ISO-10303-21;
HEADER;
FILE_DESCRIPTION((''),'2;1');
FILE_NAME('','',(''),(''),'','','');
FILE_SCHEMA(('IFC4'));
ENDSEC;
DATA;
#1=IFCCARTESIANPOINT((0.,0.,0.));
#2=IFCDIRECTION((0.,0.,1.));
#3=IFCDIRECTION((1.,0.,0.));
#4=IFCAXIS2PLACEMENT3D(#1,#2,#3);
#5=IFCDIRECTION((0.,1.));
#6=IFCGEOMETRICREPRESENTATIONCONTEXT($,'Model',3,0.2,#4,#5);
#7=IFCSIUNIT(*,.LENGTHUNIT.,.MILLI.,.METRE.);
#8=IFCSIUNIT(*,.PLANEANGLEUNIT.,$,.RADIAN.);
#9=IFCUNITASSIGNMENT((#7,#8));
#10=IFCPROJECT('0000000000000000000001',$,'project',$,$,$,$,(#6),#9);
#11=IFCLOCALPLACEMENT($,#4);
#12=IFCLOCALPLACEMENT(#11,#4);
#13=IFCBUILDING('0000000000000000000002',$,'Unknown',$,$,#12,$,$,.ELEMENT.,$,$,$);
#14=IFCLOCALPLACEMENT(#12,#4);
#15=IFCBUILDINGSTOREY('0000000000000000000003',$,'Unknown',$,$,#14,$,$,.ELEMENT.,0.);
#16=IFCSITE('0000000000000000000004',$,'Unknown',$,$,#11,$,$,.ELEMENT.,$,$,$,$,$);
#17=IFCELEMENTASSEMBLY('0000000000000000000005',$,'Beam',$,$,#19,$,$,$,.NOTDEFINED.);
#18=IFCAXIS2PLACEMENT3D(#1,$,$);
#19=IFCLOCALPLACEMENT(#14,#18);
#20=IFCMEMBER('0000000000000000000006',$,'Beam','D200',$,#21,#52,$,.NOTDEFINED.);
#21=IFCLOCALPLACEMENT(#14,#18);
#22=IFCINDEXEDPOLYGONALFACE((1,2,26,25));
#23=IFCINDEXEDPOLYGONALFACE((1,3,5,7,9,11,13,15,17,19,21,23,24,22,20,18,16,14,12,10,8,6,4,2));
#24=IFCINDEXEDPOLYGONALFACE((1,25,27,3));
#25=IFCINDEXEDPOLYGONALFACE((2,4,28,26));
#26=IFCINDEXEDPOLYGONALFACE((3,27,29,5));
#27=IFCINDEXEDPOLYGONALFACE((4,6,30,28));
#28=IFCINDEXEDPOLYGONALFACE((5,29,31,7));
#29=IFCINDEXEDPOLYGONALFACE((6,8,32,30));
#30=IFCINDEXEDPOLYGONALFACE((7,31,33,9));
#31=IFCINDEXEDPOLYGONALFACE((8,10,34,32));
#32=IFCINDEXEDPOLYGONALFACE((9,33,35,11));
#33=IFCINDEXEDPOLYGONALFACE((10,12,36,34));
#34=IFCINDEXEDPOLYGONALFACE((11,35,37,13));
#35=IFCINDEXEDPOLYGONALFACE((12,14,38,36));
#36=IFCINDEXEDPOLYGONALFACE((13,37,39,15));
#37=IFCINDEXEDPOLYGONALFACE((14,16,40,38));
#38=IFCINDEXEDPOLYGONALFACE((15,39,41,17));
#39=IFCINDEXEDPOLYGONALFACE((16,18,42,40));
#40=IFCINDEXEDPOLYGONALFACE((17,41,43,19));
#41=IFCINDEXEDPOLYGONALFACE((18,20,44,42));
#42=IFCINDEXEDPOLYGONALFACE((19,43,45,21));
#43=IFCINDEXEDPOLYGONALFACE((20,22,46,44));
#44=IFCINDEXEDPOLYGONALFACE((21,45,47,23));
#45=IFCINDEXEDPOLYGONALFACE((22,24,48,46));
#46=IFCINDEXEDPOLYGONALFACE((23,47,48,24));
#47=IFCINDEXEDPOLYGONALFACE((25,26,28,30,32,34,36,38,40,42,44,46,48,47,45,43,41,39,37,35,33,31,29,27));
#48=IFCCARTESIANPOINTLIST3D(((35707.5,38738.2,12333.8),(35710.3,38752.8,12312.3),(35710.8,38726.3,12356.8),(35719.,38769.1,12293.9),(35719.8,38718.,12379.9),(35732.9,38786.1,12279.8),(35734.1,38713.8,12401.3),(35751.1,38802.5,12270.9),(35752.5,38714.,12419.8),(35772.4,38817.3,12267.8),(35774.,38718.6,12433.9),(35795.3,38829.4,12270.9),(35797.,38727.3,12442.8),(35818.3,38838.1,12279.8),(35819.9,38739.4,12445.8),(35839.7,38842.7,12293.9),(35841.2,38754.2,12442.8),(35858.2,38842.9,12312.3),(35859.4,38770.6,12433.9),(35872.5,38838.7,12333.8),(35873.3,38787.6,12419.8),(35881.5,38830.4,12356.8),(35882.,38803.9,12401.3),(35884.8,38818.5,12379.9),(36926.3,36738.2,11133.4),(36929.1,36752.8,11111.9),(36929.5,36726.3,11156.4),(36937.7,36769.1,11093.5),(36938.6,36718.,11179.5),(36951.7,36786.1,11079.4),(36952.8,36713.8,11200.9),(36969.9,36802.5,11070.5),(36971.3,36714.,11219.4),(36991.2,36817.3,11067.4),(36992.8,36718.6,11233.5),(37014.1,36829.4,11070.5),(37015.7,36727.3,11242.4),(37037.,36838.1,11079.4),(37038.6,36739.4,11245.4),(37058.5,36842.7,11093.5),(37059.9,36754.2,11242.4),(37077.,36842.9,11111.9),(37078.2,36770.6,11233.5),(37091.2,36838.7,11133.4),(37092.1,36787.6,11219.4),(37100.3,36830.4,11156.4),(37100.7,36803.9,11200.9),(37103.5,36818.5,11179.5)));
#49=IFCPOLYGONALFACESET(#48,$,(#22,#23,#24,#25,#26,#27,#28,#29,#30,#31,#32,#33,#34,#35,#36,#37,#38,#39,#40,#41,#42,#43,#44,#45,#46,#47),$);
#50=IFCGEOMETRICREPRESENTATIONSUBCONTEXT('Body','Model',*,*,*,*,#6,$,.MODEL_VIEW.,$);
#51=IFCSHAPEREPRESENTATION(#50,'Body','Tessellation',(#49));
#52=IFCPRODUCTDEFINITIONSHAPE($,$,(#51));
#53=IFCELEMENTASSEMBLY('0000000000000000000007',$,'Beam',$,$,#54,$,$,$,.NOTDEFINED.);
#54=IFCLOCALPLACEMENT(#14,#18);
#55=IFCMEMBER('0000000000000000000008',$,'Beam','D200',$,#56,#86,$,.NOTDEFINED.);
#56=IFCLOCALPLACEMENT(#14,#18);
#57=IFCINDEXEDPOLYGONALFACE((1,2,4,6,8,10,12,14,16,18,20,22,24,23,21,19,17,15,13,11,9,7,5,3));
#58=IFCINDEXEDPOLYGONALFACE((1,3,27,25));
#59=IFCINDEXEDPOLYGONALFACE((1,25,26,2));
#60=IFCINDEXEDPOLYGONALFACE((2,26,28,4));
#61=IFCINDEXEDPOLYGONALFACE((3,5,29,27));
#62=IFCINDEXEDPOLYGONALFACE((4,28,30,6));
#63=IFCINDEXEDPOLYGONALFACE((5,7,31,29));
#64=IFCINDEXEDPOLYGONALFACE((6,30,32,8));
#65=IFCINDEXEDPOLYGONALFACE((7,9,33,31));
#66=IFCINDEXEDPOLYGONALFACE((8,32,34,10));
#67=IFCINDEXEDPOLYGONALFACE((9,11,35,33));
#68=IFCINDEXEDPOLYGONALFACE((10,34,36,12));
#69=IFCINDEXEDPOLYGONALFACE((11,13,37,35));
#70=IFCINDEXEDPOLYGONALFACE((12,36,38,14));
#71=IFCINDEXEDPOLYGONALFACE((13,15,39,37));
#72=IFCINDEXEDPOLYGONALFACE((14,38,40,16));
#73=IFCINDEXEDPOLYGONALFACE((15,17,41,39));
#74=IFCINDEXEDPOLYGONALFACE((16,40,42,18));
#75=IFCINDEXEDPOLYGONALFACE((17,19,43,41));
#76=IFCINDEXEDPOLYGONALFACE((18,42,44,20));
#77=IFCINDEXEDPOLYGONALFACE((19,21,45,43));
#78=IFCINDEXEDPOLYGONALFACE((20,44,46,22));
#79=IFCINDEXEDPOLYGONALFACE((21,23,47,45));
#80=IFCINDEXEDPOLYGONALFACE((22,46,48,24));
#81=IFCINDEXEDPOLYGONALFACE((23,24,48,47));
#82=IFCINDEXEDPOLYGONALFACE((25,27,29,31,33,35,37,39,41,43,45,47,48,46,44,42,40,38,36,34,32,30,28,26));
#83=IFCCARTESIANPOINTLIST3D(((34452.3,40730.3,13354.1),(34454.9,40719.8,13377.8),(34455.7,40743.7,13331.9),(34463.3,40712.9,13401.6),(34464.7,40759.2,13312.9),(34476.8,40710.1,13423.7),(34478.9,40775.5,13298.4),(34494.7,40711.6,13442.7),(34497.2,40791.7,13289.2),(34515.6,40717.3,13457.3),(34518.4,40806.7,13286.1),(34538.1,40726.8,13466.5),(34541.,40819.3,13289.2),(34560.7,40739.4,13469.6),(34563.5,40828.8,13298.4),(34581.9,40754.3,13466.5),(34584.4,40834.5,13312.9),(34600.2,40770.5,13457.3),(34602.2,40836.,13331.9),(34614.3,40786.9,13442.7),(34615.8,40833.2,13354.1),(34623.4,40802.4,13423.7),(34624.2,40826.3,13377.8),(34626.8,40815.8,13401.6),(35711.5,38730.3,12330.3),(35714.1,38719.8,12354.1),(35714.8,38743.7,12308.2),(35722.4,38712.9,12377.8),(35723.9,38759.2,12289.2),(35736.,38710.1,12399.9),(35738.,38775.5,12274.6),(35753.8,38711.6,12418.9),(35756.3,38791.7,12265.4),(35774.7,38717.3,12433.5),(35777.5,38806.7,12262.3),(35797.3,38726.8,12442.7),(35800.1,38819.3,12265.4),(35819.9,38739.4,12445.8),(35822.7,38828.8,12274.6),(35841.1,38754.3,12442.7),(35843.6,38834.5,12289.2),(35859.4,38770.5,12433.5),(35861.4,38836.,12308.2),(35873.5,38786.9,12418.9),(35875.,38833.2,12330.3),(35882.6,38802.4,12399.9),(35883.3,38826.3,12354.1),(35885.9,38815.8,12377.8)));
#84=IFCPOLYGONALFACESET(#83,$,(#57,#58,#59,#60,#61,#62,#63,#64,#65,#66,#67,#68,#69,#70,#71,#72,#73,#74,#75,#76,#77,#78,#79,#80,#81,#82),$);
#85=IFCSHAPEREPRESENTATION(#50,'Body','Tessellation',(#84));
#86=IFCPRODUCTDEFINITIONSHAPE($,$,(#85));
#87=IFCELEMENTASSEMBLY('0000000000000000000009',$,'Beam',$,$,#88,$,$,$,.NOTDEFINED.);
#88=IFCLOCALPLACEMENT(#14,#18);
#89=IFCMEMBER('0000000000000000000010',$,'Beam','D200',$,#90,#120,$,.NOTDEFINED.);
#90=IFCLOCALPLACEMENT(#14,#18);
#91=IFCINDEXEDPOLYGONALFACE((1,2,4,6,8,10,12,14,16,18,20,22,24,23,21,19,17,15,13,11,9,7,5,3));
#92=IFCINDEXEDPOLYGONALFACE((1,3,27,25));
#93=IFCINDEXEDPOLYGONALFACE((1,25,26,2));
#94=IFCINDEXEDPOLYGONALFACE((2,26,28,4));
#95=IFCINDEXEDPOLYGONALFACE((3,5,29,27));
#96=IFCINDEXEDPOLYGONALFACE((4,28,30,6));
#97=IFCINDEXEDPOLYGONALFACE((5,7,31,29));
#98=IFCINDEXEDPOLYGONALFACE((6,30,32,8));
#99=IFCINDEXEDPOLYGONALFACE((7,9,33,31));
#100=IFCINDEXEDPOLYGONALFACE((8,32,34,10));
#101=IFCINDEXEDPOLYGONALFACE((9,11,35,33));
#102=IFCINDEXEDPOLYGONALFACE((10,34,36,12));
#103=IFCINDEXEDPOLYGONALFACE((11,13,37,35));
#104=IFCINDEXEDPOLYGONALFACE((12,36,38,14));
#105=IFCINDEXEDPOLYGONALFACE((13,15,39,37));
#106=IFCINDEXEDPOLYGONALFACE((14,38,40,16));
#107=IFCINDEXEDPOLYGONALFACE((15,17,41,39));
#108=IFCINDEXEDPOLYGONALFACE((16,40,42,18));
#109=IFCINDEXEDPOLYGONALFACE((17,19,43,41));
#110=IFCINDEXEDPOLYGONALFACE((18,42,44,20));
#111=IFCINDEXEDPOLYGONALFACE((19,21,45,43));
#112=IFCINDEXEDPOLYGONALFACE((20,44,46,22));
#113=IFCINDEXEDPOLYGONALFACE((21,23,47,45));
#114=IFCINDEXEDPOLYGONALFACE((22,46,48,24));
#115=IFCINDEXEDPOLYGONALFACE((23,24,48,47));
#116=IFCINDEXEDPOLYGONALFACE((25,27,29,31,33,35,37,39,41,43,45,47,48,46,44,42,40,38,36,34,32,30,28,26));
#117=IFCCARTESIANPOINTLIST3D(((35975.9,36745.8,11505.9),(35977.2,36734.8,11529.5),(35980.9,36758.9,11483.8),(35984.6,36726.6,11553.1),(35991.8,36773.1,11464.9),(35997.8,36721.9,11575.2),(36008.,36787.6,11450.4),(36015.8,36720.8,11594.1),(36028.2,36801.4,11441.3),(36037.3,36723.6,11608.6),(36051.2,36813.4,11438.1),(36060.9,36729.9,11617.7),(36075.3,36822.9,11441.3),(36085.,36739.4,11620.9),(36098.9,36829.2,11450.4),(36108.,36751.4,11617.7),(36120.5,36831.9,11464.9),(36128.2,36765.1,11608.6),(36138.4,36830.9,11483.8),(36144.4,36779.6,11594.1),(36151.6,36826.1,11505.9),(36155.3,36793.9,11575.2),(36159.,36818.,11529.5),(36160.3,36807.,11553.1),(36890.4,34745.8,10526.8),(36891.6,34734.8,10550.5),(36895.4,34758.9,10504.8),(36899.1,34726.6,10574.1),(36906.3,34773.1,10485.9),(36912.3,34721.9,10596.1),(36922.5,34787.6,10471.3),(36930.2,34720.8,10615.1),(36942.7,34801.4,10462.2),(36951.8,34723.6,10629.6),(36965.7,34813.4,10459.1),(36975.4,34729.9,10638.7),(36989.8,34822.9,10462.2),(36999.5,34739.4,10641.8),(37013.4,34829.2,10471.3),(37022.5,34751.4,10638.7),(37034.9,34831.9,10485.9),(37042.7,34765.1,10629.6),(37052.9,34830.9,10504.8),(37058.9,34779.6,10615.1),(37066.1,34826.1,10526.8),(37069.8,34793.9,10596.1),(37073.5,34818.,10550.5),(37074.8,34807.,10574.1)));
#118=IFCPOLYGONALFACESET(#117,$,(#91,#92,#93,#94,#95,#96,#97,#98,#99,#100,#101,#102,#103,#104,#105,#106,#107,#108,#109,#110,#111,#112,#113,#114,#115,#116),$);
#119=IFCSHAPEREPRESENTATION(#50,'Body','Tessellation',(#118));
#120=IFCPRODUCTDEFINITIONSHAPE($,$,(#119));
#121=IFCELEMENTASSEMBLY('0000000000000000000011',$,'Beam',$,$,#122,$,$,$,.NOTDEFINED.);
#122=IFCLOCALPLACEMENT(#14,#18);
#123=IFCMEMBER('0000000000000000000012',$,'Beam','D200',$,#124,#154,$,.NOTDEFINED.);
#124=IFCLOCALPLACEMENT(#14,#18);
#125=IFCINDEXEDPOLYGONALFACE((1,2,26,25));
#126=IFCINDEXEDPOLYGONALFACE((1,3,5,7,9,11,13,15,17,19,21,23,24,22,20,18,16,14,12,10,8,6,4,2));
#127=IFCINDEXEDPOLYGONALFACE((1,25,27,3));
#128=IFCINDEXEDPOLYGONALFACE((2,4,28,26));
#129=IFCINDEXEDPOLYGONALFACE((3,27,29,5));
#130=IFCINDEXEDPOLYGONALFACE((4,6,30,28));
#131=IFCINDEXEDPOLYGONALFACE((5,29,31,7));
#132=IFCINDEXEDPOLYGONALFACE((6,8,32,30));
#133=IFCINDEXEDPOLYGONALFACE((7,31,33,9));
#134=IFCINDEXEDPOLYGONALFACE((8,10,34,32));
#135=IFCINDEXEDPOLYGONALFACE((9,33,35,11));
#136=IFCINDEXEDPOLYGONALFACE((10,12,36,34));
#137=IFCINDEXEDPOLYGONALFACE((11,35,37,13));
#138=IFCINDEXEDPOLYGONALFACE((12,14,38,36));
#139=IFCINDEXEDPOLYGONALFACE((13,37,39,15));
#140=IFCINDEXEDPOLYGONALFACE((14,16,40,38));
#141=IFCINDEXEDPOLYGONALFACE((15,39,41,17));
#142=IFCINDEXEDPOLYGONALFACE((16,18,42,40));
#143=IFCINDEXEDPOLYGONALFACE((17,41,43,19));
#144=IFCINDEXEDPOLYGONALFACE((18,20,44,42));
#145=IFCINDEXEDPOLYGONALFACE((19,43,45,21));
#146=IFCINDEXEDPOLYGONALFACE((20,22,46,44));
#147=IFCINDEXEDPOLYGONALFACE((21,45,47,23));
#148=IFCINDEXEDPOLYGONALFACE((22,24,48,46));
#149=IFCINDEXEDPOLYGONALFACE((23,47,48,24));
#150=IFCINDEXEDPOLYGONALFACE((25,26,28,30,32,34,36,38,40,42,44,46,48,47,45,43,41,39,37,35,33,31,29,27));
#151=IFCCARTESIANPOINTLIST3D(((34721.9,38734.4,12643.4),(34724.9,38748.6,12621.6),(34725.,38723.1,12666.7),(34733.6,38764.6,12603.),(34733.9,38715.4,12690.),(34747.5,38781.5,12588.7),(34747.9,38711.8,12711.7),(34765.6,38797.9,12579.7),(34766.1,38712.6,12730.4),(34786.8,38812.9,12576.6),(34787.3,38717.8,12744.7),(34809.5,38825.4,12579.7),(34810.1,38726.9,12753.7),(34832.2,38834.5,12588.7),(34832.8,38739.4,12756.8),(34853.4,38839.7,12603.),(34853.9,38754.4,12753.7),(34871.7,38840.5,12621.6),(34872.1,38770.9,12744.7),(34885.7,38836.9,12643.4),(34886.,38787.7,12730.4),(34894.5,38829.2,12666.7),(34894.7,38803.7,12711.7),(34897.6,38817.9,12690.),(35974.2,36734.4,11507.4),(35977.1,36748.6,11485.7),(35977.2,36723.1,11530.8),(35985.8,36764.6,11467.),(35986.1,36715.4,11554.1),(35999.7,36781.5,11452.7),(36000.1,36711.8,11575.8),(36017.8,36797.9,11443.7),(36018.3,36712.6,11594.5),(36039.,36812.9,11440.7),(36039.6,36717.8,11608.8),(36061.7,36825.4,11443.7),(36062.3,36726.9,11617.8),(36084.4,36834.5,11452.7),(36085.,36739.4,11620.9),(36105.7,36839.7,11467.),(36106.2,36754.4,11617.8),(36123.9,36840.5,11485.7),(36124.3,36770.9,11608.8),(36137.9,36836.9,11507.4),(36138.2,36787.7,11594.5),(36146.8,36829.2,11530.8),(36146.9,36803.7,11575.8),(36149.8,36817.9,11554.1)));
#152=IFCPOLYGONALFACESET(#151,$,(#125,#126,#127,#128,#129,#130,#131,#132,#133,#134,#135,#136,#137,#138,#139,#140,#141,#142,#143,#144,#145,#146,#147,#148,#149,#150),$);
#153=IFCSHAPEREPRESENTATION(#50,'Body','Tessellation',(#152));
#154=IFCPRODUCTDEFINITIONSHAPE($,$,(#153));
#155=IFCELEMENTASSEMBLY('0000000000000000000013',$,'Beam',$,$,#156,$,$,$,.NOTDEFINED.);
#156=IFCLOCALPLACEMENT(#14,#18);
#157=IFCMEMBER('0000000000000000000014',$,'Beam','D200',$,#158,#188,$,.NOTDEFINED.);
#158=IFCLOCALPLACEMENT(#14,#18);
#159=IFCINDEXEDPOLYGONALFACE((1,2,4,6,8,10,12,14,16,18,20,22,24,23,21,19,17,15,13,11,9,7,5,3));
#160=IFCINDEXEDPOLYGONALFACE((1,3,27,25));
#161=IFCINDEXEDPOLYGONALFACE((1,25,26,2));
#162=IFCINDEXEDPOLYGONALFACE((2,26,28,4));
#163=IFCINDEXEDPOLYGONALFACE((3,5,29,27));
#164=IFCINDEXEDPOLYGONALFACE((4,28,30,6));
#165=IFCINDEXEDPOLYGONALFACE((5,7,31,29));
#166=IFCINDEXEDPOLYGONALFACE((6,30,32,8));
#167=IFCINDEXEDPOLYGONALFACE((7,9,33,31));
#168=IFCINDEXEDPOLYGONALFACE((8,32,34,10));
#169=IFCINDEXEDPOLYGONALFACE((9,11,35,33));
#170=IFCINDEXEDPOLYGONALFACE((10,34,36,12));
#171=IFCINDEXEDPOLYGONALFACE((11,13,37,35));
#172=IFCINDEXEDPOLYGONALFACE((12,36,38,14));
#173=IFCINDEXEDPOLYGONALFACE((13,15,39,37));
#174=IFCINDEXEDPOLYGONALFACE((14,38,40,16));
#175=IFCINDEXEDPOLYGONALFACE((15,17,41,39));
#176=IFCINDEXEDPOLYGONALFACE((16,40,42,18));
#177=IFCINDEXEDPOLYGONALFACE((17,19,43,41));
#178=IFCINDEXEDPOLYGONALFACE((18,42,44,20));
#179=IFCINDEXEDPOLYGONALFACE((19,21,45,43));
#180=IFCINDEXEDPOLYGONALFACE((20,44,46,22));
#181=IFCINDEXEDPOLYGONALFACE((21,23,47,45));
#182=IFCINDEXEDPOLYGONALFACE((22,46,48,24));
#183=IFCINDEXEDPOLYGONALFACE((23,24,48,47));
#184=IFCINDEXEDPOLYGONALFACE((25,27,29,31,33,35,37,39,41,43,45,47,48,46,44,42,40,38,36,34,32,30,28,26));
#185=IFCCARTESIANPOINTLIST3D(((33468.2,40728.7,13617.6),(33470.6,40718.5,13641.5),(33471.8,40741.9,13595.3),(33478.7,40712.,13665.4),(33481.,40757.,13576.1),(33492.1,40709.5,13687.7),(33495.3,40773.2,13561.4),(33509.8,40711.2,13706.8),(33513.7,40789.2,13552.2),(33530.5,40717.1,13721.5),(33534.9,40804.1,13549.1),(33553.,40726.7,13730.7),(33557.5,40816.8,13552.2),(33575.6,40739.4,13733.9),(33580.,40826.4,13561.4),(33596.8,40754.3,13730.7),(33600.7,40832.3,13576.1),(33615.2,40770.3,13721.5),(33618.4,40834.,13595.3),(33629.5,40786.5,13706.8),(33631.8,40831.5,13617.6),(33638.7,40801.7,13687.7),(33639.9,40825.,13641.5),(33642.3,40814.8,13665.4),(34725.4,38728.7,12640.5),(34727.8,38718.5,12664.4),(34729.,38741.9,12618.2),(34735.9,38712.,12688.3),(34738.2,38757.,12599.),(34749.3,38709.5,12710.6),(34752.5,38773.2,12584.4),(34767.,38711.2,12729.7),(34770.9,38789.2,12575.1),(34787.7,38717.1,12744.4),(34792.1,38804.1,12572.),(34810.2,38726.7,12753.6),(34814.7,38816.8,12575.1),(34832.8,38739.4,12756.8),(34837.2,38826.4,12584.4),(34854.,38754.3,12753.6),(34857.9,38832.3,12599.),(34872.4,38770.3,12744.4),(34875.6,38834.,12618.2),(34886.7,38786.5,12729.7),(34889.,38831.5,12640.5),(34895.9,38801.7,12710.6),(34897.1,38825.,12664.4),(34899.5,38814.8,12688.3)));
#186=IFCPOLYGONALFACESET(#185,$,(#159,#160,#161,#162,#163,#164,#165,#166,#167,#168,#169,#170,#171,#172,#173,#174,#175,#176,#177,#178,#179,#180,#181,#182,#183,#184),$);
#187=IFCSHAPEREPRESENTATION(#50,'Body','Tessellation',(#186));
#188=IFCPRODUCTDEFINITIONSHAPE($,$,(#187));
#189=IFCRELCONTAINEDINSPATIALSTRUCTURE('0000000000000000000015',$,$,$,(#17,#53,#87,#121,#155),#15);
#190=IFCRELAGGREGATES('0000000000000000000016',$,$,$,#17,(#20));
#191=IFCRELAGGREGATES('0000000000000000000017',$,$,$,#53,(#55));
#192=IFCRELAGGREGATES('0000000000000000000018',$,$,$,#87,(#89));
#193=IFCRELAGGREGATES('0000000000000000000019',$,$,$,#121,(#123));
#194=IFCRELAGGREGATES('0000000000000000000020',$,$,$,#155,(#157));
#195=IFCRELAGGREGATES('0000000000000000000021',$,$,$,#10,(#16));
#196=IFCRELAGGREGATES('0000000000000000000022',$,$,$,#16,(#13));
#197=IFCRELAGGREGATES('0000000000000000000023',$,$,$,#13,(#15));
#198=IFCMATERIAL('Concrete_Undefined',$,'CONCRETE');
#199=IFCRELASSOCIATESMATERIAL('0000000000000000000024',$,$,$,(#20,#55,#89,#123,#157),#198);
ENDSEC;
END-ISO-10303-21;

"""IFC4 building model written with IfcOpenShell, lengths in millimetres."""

from ifc_helpers import new_model, si_unit, direction, frame, origin_with_axes, place, context, subcontext, project, spatial, line, indexed_curve, outline, extrude, material, element, aggregate, save


model = new_model("IFC4")

# Units and contexts
model_context = context("Model", 3, precision=0.2, world=origin_with_axes(), true_north=direction((0.0, 1.0)))
body_context = subcontext(model_context, "Body", "Model", "MODEL_VIEW")
ifc_project = project(units=[si_unit("LENGTHUNIT", "METRE", prefix="MILLI"), si_unit("PLANEANGLEUNIT", "RADIAN")], contexts=[model_context])

# Site, building, storey
site_placement = place(None, origin_with_axes())
site = spatial("IfcSite", under=ifc_project, at=site_placement, Name="Unknown", CompositionType="ELEMENT")
building_placement = place(site_placement, origin_with_axes())
building = spatial("IfcBuilding", under=site, at=building_placement, Name="Unknown", CompositionType="ELEMENT")
storey_placement = place(building_placement, origin_with_axes())
storey = spatial("IfcBuildingStorey", under=building, at=storey_placement, Name="Unknown", CompositionType="ELEMENT", Elevation=0.0)

# Shared definitions
ifc_material = material(Name="Concrete_Undefined", Category="CONCRETE")

# Element assemblies, members
assembly_1_placement = place(storey_placement, frame((35796.1, 38778.4, 12356.8), z_axis=(-0.853939, -0.520374, 0.0), x_axis=(0.463091, -0.759937, -0.456116)))
assembly_1 = element("IfcElementAssembly", 1, at=assembly_1_placement, inside=storey, Name="Beam", PredefinedType="NOTDEFINED")
member_1_placement = place(assembly_1_placement, origin_with_axes())
member_1 = element("IfcMember", 2, at=member_1_placement, material=ifc_material, Name="Beam", Description="D200", PredefinedType="NOTDEFINED", context=body_context, shape_type="SolidModel", body=[
    extrude(outline(indexed_curve([(100.0, 0.0), (96.6, 25.9), (86.6, 50.0), (70.7, 70.7), (50.0, 86.6), (25.9, 96.6), (0.0, 100.0), (-25.9, 96.6), (-50.0, 86.6), (-70.7, 70.7), (-86.6, 50.0), (-96.6, 25.9), (-100.0, 0.0), (-96.6, -25.9), (-86.6, -50.0), (-70.7, -70.7), (-50.0, -86.6), (-25.9, -96.6), (0.0, -100.0), (25.9, -96.6), (50.0, -86.6), (70.7, -70.7), (86.6, -50.0), (96.6, -25.9)], segments=[line(1, 2, 3, 4, 5, 6, 7, 8, 9, 10, 11, 12, 13, 14, 15, 16, 17, 18, 19, 20, 21, 22, 23, 24, 1)])), frame((0.0, 0.0, 0.0), z_axis=(-1.0, 0.0, 0.0), x_axis=(0.0, 0.0, 1.0)), (0.0, 0.0, -1.0), 2631.8),
])
aggregate(assembly_1, [member_1])
assembly_2_placement = place(storey_placement, frame((34539.5, 40773.0, 13377.8), z_axis=(-0.846249, -0.532787, 0.0), x_axis=(0.488889, -0.776524, -0.397489)))
assembly_2 = element("IfcElementAssembly", 3, at=assembly_2_placement, inside=storey, Name="Beam", PredefinedType="NOTDEFINED")
member_2_placement = place(assembly_2_placement, origin_with_axes())
member_2 = element("IfcMember", 4, at=member_2_placement, material=ifc_material, Name="Beam", Description="D200", PredefinedType="NOTDEFINED", context=body_context, shape_type="SolidModel", body=[
    extrude(outline(indexed_curve([(100.0, 0.0), (96.6, 25.9), (86.6, 50.0), (70.7, 70.7), (50.0, 86.6), (25.9, 96.6), (0.0, 100.0), (-25.9, 96.6), (-50.0, 86.6), (-70.7, 70.7), (-86.6, 50.0), (-96.6, 25.9), (-100.0, 0.0), (-96.6, -25.9), (-86.6, -50.0), (-70.7, -70.7), (-50.0, -86.6), (-25.9, -96.6), (0.0, -100.0), (25.9, -96.6), (50.0, -86.6), (70.7, -70.7), (86.6, -50.0), (96.6, -25.9)], segments=[line(1, 2, 3, 4, 5, 6, 7, 8, 9, 10, 11, 12, 13, 14, 15, 16, 17, 18, 19, 20, 21, 22, 23, 24, 1)])), frame((0.0, 0.0, 0.0), z_axis=(-1.0, 0.0, 0.0), x_axis=(0.0, 0.0, 1.0)), (0.0, 0.0, -1.0), 2575.6),
])
aggregate(assembly_2, [member_2])

# Element assemblies, members
assembly_3_placement = place(storey_placement, frame((36068.1, 36776.4, 11529.5), z_axis=(-0.909439, -0.415837, 0.0), x_axis=(0.379892, -0.830827, -0.406705)))
assembly_3 = element("IfcElementAssembly", 5, at=assembly_3_placement, inside=storey, Name="Beam", PredefinedType="NOTDEFINED")
member_3_placement = place(assembly_3_placement, origin_with_axes())
member_3 = element("IfcMember", 6, at=member_3_placement, material=ifc_material, Name="Beam", Description="D200", PredefinedType="NOTDEFINED", context=body_context, shape_type="SolidModel", body=[
    extrude(outline(indexed_curve([(100.0, 0.0), (96.6, 25.9), (86.6, 50.0), (70.7, 70.7), (50.0, 86.6), (25.9, 96.6), (0.0, 100.0), (-25.9, 96.6), (-50.0, 86.6), (-70.7, 70.7), (-86.6, 50.0), (-96.6, 25.9), (-100.0, 0.0), (-96.6, -25.9), (-86.6, -50.0), (-70.7, -70.7), (-50.0, -86.6), (-25.9, -96.6), (0.0, -100.0), (25.9, -96.6), (50.0, -86.6), (70.7, -70.7), (86.6, -50.0), (96.6, -25.9)], segments=[line(1, 2, 3, 4, 5, 6, 7, 8, 9, 10, 11, 12, 13, 14, 15, 16, 17, 18, 19, 20, 21, 22, 23, 24, 1)])), frame((0.0, 0.0, 0.0), z_axis=(-1.0, 0.0, 0.0), x_axis=(0.0, 0.0, 1.0)), (0.0, 0.0, -1.0), 2407.2),
])
aggregate(assembly_3, [member_3])
assembly_4_placement = place(storey_placement, frame((34809.8, 38776.2, 12666.7), z_axis=(-0.847575, -0.530676, 0.0), x_axis=(0.478156, -0.763692, -0.433754)))
assembly_4 = element("IfcElementAssembly", 7, at=assembly_4_placement, inside=storey, Name="Beam", PredefinedType="NOTDEFINED")
member_4_placement = place(assembly_4_placement, origin_with_axes())
member_4 = element("IfcMember", 8, at=member_4_placement, material=ifc_material, Name="Beam", Description="D200", PredefinedType="NOTDEFINED", context=body_context, shape_type="SolidModel", body=[
    extrude(outline(indexed_curve([(100.0, 0.0), (96.6, 25.9), (86.6, 50.0), (70.7, 70.7), (50.0, 86.6), (25.9, 96.6), (0.0, 100.0), (-25.9, 96.6), (-50.0, 86.6), (-70.7, 70.7), (-86.6, 50.0), (-96.6, 25.9), (-100.0, 0.0), (-96.6, -25.9), (-86.6, -50.0), (-70.7, -70.7), (-50.0, -86.6), (-25.9, -96.6), (0.0, -100.0), (25.9, -96.6), (50.0, -86.6), (70.7, -70.7), (86.6, -50.0), (96.6, -25.9)], segments=[line(1, 2, 3, 4, 5, 6, 7, 8, 9, 10, 11, 12, 13, 14, 15, 16, 17, 18, 19, 20, 21, 22, 23, 24, 1)])), frame((0.0, 0.0, 0.0), z_axis=(-1.0, 0.0, 0.0), x_axis=(0.0, 0.0, 1.0)), (0.0, 0.0, -1.0), 2618.9),
])
aggregate(assembly_4, [member_4])
assembly_5_placement = place(storey_placement, frame((33555.3, 40771.8, 13641.5), z_axis=(-0.846626, -0.532188, 0.0), x_axis=(0.491782, -0.782347, -0.382209)))
assembly_5 = element("IfcElementAssembly", 9, at=assembly_5_placement, inside=storey, Name="Beam", PredefinedType="NOTDEFINED")
member_5_placement = place(assembly_5_placement, origin_with_axes())
member_5 = element("IfcMember", 10, at=member_5_placement, material=ifc_material, Name="Beam", Description="D200", PredefinedType="NOTDEFINED", context=body_context, shape_type="SolidModel", body=[
    extrude(outline(indexed_curve([(100.0, 0.0), (96.6, 25.9), (86.6, 50.0), (70.7, 70.7), (50.0, 86.6), (25.9, 96.6), (0.0, 100.0), (-25.9, 96.6), (-50.0, 86.6), (-70.7, 70.7), (-86.6, 50.0), (-96.6, 25.9), (-100.0, 0.0), (-96.6, -25.9), (-86.6, -50.0), (-70.7, -70.7), (-50.0, -86.6), (-25.9, -96.6), (0.0, -100.0), (25.9, -96.6), (50.0, -86.6), (70.7, -70.7), (86.6, -50.0), (96.6, -25.9)], segments=[line(1, 2, 3, 4, 5, 6, 7, 8, 9, 10, 11, 12, 13, 14, 15, 16, 17, 18, 19, 20, 21, 22, 23, 24, 1)])), frame((0.0, 0.0, 0.0), z_axis=(-1.0, 0.0, 0.0), x_axis=(0.0, 0.0, 1.0)), (0.0, 0.0, -1.0), 2556.4),
])
aggregate(assembly_5, [member_5])

save(model, "model.ifc")
